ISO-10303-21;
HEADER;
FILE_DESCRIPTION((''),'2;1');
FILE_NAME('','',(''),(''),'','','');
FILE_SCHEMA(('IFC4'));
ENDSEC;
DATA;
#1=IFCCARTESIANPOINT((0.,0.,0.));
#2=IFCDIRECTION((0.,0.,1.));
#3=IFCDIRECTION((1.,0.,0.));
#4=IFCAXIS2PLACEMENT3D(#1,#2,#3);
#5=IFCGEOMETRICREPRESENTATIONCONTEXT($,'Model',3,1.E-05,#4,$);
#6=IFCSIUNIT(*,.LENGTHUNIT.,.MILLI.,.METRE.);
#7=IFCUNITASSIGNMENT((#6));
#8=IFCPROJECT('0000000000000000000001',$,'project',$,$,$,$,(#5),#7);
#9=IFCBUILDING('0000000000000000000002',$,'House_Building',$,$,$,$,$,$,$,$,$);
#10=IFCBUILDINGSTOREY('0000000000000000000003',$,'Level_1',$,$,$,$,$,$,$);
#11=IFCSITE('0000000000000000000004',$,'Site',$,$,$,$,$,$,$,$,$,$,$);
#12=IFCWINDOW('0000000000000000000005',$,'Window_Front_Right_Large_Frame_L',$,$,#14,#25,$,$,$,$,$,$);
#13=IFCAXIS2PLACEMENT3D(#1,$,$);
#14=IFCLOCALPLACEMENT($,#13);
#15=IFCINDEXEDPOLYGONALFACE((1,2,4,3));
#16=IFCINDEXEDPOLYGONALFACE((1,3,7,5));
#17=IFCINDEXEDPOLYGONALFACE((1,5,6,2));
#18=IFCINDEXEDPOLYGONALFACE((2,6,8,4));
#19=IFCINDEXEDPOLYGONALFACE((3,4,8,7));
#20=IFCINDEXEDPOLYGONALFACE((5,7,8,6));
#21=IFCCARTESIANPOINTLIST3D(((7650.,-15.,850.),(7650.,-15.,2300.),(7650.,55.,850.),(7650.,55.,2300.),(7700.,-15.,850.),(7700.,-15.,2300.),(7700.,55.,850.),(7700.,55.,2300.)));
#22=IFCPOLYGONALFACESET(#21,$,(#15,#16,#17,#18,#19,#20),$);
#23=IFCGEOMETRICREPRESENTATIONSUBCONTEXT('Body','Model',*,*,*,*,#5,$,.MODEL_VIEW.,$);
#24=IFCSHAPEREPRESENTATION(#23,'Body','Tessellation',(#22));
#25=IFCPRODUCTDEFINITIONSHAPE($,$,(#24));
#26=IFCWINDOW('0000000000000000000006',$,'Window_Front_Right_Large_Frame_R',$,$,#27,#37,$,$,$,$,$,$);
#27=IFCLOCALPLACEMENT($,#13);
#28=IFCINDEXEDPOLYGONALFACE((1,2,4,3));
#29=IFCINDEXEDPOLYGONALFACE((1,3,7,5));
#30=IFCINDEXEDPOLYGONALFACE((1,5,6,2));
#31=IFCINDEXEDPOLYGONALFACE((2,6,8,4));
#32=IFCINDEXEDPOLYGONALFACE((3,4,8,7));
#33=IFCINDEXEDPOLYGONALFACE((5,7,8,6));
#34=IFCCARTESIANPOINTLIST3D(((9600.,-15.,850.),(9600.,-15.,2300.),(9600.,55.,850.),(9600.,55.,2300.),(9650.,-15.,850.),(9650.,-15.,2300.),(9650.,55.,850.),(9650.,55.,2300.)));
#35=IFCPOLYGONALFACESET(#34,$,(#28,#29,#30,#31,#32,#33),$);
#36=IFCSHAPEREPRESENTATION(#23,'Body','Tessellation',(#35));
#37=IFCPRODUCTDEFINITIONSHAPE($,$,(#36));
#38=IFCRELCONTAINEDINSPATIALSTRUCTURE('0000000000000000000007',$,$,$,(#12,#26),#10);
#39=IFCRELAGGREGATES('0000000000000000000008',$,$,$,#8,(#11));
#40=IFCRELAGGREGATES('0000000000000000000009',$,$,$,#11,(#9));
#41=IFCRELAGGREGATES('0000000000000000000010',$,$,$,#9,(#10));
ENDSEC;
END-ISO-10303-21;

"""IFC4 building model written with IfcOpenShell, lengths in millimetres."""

from ifc_helpers import new_model, si_unit, frame, origin_with_axes, context, subcontext, project, spatial, polyline, outline, extrude, element, save


model = new_model("IFC4")

# Units and contexts
model_context = context("Model", 3, precision=1e-05, world=origin_with_axes())
body_context = subcontext(model_context, "Body", "Model", "MODEL_VIEW")
ifc_project = project(units=[si_unit("LENGTHUNIT", "METRE", prefix="MILLI")], contexts=[model_context])

# Site, building, storey
site = spatial("IfcSite", under=ifc_project, Name="Site")
building = spatial("IfcBuilding", under=site, Name="House_Building")
storey = spatial("IfcBuildingStorey", under=building, Name="Level_1")

# Windows
element("IfcWindow", 1, inside=storey, Name="Window_Front_Right_Large_Frame_L", context=body_context, shape_type="SweptSolid", body=[
    extrude(outline(polyline([(7650.0, -15.0), (7700.0, -15.0), (7700.0, 55.0), (7650.0, 55.0), (7650.0, -15.0)])), frame((0.0, 0.0, 850.0), z_axis=(0.0, 0.0, 1.0), x_axis=(1.0, 0.0, 0.0)), (0.0, 0.0, 1.0), 1450.0),
])
element("IfcWindow", 2, inside=storey, Name="Window_Front_Right_Large_Frame_R", context=body_context, shape_type="SweptSolid", body=[
    extrude(outline(polyline([(9600.0, -15.0), (9650.0, -15.0), (9650.0, 55.0), (9600.0, 55.0), (9600.0, -15.0)])), frame((0.0, 0.0, 850.0), z_axis=(0.0, 0.0, 1.0), x_axis=(1.0, 0.0, 0.0)), (0.0, 0.0, 1.0), 1450.0),
])

save(model, "model.ifc")
